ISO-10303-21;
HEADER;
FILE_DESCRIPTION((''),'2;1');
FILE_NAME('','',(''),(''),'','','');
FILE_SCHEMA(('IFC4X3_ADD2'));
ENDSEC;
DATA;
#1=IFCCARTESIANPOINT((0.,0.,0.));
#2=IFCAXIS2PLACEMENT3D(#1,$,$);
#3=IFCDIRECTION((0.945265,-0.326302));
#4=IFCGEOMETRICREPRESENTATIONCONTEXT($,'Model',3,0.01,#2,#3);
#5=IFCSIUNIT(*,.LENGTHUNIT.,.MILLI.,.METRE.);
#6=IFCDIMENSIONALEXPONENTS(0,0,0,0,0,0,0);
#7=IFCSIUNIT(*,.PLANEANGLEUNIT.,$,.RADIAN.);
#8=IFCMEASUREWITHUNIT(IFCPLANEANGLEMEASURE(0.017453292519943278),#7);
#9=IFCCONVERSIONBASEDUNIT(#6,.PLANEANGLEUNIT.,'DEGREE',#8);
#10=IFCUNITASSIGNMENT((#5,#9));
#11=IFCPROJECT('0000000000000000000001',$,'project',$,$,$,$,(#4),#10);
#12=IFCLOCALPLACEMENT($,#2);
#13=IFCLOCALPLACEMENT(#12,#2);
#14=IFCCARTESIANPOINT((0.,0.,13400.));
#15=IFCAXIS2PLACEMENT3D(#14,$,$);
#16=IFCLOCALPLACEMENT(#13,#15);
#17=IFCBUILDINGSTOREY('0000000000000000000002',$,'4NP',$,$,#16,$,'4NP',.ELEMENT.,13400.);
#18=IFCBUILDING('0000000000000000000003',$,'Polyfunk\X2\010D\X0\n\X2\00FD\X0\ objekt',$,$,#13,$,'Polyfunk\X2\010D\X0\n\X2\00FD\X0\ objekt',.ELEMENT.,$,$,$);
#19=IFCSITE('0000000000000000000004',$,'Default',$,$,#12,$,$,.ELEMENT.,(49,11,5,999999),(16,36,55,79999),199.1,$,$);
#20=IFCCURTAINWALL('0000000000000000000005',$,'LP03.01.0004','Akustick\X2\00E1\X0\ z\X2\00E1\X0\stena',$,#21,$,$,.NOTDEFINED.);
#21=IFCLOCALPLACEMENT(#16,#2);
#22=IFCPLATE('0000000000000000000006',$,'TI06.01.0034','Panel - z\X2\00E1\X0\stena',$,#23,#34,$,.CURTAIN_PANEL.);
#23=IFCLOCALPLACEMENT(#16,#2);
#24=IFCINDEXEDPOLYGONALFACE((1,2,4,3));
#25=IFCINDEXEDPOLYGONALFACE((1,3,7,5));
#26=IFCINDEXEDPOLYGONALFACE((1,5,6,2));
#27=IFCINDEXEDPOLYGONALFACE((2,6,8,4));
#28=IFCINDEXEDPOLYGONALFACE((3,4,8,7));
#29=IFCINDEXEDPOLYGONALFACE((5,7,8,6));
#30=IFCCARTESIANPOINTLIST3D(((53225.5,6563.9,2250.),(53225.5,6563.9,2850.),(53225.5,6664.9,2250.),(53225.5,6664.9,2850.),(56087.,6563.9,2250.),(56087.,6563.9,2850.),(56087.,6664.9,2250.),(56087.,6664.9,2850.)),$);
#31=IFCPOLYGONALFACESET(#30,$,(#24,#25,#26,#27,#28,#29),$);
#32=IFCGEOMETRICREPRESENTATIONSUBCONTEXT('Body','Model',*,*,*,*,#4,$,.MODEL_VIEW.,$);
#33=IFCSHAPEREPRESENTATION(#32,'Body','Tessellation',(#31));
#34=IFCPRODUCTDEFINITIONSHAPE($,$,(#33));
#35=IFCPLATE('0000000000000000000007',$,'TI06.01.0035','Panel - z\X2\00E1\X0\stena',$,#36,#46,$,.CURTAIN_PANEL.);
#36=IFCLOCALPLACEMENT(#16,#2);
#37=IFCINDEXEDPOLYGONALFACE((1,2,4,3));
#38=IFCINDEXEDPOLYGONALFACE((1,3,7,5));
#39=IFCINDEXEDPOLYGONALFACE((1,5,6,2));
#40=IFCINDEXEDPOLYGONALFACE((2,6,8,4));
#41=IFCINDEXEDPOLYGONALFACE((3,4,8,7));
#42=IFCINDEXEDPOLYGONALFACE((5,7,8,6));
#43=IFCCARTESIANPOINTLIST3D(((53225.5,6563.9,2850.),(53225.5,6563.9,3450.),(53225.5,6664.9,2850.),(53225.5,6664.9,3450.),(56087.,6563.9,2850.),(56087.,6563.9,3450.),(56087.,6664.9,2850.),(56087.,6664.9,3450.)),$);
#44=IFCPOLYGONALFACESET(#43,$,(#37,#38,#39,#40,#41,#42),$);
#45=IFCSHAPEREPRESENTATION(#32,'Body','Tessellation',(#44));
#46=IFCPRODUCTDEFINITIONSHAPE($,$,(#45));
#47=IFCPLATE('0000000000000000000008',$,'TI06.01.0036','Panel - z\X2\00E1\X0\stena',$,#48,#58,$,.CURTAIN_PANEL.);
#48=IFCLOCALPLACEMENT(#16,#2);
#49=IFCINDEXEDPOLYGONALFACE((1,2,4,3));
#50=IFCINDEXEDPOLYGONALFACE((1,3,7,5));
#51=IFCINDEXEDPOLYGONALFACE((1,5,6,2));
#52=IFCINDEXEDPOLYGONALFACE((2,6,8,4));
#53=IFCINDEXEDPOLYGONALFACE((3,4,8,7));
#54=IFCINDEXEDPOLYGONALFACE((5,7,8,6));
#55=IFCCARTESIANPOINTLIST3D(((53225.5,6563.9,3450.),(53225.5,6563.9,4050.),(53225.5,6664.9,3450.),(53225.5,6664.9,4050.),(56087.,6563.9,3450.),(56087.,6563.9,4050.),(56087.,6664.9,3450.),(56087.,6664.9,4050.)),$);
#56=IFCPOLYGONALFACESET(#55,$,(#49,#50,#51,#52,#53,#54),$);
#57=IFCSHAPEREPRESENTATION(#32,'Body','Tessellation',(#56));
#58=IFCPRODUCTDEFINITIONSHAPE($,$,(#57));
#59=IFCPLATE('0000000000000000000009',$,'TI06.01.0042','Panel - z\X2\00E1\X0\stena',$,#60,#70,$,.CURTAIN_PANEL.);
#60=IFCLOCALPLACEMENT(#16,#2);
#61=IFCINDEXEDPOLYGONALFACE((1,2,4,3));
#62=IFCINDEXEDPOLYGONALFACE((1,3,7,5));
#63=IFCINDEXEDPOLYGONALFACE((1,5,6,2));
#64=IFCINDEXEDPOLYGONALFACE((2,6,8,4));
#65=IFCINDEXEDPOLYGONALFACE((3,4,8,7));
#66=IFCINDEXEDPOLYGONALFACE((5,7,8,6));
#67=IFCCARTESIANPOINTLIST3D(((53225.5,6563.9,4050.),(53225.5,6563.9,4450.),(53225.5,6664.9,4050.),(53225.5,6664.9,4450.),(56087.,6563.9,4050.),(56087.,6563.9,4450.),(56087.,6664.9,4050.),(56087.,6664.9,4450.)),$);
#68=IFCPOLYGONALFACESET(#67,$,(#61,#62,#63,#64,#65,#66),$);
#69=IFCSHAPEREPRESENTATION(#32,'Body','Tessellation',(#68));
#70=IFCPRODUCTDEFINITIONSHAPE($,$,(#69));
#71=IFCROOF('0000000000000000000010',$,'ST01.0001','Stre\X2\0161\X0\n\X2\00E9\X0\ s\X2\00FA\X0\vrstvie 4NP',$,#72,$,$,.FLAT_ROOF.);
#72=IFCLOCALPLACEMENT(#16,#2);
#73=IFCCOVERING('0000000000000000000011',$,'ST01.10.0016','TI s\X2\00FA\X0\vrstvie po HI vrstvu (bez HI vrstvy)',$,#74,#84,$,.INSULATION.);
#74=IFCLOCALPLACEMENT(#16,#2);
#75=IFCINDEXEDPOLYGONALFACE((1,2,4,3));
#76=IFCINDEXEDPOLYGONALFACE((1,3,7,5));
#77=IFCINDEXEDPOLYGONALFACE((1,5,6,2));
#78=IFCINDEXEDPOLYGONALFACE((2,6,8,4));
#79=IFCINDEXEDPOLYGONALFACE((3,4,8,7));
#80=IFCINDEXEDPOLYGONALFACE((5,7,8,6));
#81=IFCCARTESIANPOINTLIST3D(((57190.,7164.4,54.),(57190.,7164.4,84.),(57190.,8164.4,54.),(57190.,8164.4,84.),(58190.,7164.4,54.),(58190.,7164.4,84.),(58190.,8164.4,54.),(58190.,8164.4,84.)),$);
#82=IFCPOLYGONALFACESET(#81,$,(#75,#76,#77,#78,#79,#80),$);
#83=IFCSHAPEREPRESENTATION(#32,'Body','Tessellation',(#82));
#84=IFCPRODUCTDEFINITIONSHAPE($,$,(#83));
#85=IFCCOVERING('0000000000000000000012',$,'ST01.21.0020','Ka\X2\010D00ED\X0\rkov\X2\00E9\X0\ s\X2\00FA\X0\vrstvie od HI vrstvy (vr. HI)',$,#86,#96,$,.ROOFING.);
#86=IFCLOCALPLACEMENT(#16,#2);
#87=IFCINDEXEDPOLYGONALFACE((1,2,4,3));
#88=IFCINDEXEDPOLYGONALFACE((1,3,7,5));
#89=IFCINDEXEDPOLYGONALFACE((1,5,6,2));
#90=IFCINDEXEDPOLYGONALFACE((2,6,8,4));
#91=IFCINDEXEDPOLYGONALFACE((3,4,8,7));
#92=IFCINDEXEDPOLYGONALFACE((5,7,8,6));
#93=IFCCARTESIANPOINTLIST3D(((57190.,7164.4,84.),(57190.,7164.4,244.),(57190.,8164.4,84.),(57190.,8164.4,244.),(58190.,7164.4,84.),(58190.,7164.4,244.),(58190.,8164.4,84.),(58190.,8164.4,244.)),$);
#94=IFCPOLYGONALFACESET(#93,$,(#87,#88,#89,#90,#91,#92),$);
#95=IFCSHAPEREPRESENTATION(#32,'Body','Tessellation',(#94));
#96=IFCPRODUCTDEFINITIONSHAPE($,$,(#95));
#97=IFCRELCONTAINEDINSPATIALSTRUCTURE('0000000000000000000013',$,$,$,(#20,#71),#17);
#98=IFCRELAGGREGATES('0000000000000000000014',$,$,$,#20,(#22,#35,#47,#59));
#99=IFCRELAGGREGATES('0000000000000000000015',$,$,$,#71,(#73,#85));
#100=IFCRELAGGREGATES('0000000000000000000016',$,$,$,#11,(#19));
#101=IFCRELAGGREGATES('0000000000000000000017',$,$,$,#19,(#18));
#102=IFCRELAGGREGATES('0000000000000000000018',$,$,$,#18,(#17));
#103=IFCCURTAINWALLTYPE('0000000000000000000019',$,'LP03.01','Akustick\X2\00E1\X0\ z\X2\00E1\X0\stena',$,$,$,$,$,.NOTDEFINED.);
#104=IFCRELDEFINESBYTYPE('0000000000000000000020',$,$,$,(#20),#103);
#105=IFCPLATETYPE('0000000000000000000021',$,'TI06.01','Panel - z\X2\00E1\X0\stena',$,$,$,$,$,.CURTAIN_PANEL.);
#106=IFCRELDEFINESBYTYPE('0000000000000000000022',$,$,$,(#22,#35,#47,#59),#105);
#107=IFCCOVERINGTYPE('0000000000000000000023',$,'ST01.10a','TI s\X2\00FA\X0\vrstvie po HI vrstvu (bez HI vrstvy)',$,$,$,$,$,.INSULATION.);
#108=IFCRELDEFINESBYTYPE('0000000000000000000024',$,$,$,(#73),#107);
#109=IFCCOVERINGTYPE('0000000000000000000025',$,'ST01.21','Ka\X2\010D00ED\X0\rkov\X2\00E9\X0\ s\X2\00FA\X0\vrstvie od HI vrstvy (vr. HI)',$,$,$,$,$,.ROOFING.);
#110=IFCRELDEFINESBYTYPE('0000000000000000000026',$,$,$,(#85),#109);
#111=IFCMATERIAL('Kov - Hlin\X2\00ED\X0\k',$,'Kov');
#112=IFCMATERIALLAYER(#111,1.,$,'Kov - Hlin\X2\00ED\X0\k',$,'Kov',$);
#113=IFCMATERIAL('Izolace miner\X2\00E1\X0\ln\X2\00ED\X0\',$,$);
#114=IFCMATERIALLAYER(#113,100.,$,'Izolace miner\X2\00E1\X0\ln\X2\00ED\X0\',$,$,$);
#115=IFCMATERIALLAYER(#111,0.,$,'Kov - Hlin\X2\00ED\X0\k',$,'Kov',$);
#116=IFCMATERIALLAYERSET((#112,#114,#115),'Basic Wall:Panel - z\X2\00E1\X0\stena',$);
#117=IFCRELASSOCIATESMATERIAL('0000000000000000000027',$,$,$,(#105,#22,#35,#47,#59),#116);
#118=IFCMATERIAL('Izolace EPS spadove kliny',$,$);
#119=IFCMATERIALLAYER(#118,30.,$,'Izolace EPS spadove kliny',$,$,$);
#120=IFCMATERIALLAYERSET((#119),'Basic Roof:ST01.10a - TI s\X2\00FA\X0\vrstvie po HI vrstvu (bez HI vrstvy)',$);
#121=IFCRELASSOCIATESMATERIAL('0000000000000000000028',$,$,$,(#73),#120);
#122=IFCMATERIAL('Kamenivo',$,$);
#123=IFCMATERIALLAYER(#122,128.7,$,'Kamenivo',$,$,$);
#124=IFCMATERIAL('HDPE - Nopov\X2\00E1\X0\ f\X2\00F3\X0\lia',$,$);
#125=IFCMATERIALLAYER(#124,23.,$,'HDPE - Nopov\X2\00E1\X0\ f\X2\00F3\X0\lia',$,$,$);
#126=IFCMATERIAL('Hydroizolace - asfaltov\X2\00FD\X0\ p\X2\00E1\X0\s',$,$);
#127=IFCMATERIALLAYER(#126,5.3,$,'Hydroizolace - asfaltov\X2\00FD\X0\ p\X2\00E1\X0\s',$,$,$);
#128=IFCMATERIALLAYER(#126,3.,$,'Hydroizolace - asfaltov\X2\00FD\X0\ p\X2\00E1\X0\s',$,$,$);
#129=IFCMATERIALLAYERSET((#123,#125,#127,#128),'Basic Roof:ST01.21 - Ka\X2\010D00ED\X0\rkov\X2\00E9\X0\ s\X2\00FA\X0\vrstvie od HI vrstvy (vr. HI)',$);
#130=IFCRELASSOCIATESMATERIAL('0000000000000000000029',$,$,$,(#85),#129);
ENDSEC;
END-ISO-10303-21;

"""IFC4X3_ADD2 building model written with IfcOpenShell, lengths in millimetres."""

from ifc_helpers import new_model, entity, si_unit, converted_unit, direction, frame, frame_2d, origin, origin_2d_with_axis, place, context, subcontext, project, spatial, rectangle, extrude, material, layer, layer_set, layer_usage, type_object, element, aggregate, save


model = new_model("IFC4X3_ADD2")

# Units and contexts
model_context = context("Model", 3, precision=0.01, world=origin(), true_north=direction((0.945265, -0.326302)))
body_context = subcontext(model_context, "Body", "Model", "MODEL_VIEW")
ifc_project = project(units=[si_unit("LENGTHUNIT", "METRE", prefix="MILLI"), converted_unit("PLANEANGLEUNIT", "DEGREE", entity("IfcPlaneAngleMeasure", 0.017453292519943278), si_unit("PLANEANGLEUNIT", "RADIAN"), dimensions=[0, 0, 0, 0, 0, 0, 0])], contexts=[model_context])

# Site, building, storey
site_placement = place(None, origin())
site = spatial("IfcSite", under=ifc_project, at=site_placement, Name="Default", CompositionType="ELEMENT", RefLatitude=(49, 11, 5, 999999), RefLongitude=(16, 36, 55, 79999), RefElevation=199.1)
building_placement = place(site_placement, origin())
building = spatial("IfcBuilding", under=site, at=building_placement, Name="Polyfunkčný objekt", LongName="Polyfunkčný objekt", CompositionType="ELEMENT")
storey_placement = place(building_placement, frame((0.0, 0.0, 13400.0)))
storey = spatial("IfcBuildingStorey", under=building, at=storey_placement, Name="4NP", LongName="4NP", CompositionType="ELEMENT", Elevation=13400.0)

# Curtain wall, plates
curtain_wall_type = type_object("IfcCurtainWallType", Name="LP03.01", Description="Akustická zástena", PredefinedType="NOTDEFINED")
curtain_wall_placement = place(storey_placement, frame((0.0, 0.0, -13400.0)))
curtain_wall = element("IfcCurtainWall", 1, at=curtain_wall_placement, inside=storey, type_object=curtain_wall_type, Name="LP03.01.0004", Description="Akustická zástena", PredefinedType="NOTDEFINED")
ifc_material_1 = material(Name="Kov - Hliník", Category="Kov")
ifc_layer_1 = layer(ifc_material_1, 1.0, Name="Kov - Hliník", Category="Kov")
ifc_material_2 = material(Name="Izolace minerální")
ifc_layer_2 = layer(ifc_material_2, 100.0, Name="Izolace minerální")
ifc_layer_3 = layer(ifc_material_1, 0.0, Name="Kov - Hliník", Category="Kov")
ifc_layer_set_1 = layer_set([ifc_layer_1, ifc_layer_2, ifc_layer_3], Name="Basic Wall:Panel - zástena")
plate_type = type_object("IfcPlateType", Name="TI06.01", Description="Panel - zástena", PredefinedType="CURTAIN_PANEL", material=ifc_layer_set_1)
ifc_layer_usage_1 = layer_usage(ifc_layer_set_1, "AXIS2", "POSITIVE", -50.5)
plate_1_placement = place(storey_placement, frame((53225.5, 6614.4, 2250.0)))
plate_1 = element("IfcPlate", 2, at=plate_1_placement, type_object=plate_type, material=ifc_layer_usage_1, Name="TI06.01.0034", Description="Panel - zástena", PredefinedType="CURTAIN_PANEL", context=body_context, shape_type="SweptSolid", body=[
    extrude(rectangle(XDim=101.0, YDim=2861.5, at=frame_2d((0.0, 0.0), x_axis=(1.0, 0.0))), frame((1430.7, 0.0, 0.0), z_axis=(0.0, 0.0, 1.0), x_axis=(0.0, 1.0, 0.0)), (0.0, 0.0, 1.0), 600.0),
])
ifc_layer_usage_2 = layer_usage(ifc_layer_set_1, "AXIS2", "POSITIVE", -50.5)
plate_2_placement = place(storey_placement, frame((53225.5, 6614.4, 2850.0)))
plate_2 = element("IfcPlate", 3, at=plate_2_placement, type_object=plate_type, material=ifc_layer_usage_2, Name="TI06.01.0035", Description="Panel - zástena", PredefinedType="CURTAIN_PANEL", context=body_context, shape_type="SweptSolid", body=[
    extrude(rectangle(XDim=101.0, YDim=2861.5, at=frame_2d((0.0, 0.0), x_axis=(1.0, 0.0))), frame((1430.7, 0.0, 0.0), z_axis=(0.0, 0.0, 1.0), x_axis=(0.0, 1.0, 0.0)), (0.0, 0.0, 1.0), 600.0),
])
ifc_layer_usage_3 = layer_usage(ifc_layer_set_1, "AXIS2", "POSITIVE", -50.5)
plate_3_placement = place(storey_placement, frame((53225.5, 6614.4, 3450.0)))
plate_3 = element("IfcPlate", 4, at=plate_3_placement, type_object=plate_type, material=ifc_layer_usage_3, Name="TI06.01.0036", Description="Panel - zástena", PredefinedType="CURTAIN_PANEL", context=body_context, shape_type="SweptSolid", body=[
    extrude(rectangle(XDim=101.0, YDim=2861.5, at=origin_2d_with_axis()), frame((1430.8, 0.0, 0.0), z_axis=(0.0, 0.0, 1.0), x_axis=(0.0, 1.0, 0.0)), (0.0, 0.0, 1.0), 600.0),
])
ifc_layer_usage_4 = layer_usage(ifc_layer_set_1, "AXIS2", "POSITIVE", -50.5)
plate_4_placement = place(storey_placement, frame((53225.5, 6614.4, 4050.0)))
plate_4 = element("IfcPlate", 5, at=plate_4_placement, type_object=plate_type, material=ifc_layer_usage_4, Name="TI06.01.0042", Description="Panel - zástena", PredefinedType="CURTAIN_PANEL", context=body_context, shape_type="SweptSolid", body=[
    extrude(rectangle(XDim=101.0, YDim=2861.5, at=origin_2d_with_axis()), frame((1430.8, 0.0, 0.0), z_axis=(0.0, 0.0, 1.0), x_axis=(0.0, 1.0, 0.0)), (0.0, 0.0, 1.0), 400.0),
])
aggregate(curtain_wall, [plate_1, plate_2, plate_3, plate_4])

# Roof, coverings
roof = element("IfcRoof", 6, inside=storey, Name="ST01.0001", Description="Strešné súvrstvie 4NP", PredefinedType="FLAT_ROOF")
ifc_material_3 = material(Name="Izolace EPS spadove kliny")
ifc_layer_4 = layer(ifc_material_3, 30.0, Name="Izolace EPS spadove kliny")
ifc_layer_set_2 = layer_set([ifc_layer_4], Name="Basic Roof:ST01.10a - TI súvrstvie po HI vrstvu (bez HI vrstvy)")
covering_type_1 = type_object("IfcCoveringType", Name="ST01.10a", Description="TI súvrstvie po HI vrstvu (bez HI vrstvy)", PredefinedType="INSULATION")
placement_1 = place(storey_placement, frame((57190.0, 7164.4, 54.0)))
covering_1_placement = place(placement_1, origin())
covering_1 = element("IfcCovering", 7, at=covering_1_placement, type_object=covering_type_1, material=ifc_layer_set_2, Name="ST01.10.0016", Description="TI súvrstvie po HI vrstvu (bez HI vrstvy)", PredefinedType="INSULATION", context=body_context, shape_type="SweptSolid", body=[
    extrude(rectangle(XDim=1000.0, YDim=1000.0, at=frame_2d((0.0, 0.0), x_axis=(1.0, 0.0))), frame((500.0, 500.0, 0.0)), (0.0, 0.0, 1.0), 30.0),
])
ifc_material_4 = material(Name="Kamenivo")
ifc_layer_5 = layer(ifc_material_4, 128.7, Name="Kamenivo")
ifc_material_5 = material(Name="HDPE - Nopová fólia")
ifc_layer_6 = layer(ifc_material_5, 23.0, Name="HDPE - Nopová fólia")
ifc_material_6 = material(Name="Hydroizolace - asfaltový pás")
ifc_layer_7 = layer(ifc_material_6, 5.3, Name="Hydroizolace - asfaltový pás")
ifc_layer_8 = layer(ifc_material_6, 3.0, Name="Hydroizolace - asfaltový pás")
ifc_layer_set_3 = layer_set([ifc_layer_5, ifc_layer_6, ifc_layer_7, ifc_layer_8], Name="Basic Roof:ST01.21 - Kačírkové súvrstvie od HI vrstvy (vr. HI)")
covering_type_2 = type_object("IfcCoveringType", Name="ST01.21", Description="Kačírkové súvrstvie od HI vrstvy (vr. HI)", PredefinedType="ROOFING")
placement_2 = place(storey_placement, frame((57190.0, 7164.4, 84.0)))
covering_2_placement = place(placement_2, origin())
covering_2 = element("IfcCovering", 8, at=covering_2_placement, type_object=covering_type_2, material=ifc_layer_set_3, Name="ST01.21.0020", Description="Kačírkové súvrstvie od HI vrstvy (vr. HI)", PredefinedType="ROOFING", context=body_context, shape_type="SweptSolid", body=[
    extrude(rectangle(XDim=1000.0, YDim=1000.0, at=frame_2d((0.0, 0.0), x_axis=(1.0, 0.0))), frame((500.0, 500.0, 0.0)), (0.0, 0.0, 1.0), 160.0),
])
aggregate(roof, [covering_1, covering_2])

save(model, "model.ifc")
